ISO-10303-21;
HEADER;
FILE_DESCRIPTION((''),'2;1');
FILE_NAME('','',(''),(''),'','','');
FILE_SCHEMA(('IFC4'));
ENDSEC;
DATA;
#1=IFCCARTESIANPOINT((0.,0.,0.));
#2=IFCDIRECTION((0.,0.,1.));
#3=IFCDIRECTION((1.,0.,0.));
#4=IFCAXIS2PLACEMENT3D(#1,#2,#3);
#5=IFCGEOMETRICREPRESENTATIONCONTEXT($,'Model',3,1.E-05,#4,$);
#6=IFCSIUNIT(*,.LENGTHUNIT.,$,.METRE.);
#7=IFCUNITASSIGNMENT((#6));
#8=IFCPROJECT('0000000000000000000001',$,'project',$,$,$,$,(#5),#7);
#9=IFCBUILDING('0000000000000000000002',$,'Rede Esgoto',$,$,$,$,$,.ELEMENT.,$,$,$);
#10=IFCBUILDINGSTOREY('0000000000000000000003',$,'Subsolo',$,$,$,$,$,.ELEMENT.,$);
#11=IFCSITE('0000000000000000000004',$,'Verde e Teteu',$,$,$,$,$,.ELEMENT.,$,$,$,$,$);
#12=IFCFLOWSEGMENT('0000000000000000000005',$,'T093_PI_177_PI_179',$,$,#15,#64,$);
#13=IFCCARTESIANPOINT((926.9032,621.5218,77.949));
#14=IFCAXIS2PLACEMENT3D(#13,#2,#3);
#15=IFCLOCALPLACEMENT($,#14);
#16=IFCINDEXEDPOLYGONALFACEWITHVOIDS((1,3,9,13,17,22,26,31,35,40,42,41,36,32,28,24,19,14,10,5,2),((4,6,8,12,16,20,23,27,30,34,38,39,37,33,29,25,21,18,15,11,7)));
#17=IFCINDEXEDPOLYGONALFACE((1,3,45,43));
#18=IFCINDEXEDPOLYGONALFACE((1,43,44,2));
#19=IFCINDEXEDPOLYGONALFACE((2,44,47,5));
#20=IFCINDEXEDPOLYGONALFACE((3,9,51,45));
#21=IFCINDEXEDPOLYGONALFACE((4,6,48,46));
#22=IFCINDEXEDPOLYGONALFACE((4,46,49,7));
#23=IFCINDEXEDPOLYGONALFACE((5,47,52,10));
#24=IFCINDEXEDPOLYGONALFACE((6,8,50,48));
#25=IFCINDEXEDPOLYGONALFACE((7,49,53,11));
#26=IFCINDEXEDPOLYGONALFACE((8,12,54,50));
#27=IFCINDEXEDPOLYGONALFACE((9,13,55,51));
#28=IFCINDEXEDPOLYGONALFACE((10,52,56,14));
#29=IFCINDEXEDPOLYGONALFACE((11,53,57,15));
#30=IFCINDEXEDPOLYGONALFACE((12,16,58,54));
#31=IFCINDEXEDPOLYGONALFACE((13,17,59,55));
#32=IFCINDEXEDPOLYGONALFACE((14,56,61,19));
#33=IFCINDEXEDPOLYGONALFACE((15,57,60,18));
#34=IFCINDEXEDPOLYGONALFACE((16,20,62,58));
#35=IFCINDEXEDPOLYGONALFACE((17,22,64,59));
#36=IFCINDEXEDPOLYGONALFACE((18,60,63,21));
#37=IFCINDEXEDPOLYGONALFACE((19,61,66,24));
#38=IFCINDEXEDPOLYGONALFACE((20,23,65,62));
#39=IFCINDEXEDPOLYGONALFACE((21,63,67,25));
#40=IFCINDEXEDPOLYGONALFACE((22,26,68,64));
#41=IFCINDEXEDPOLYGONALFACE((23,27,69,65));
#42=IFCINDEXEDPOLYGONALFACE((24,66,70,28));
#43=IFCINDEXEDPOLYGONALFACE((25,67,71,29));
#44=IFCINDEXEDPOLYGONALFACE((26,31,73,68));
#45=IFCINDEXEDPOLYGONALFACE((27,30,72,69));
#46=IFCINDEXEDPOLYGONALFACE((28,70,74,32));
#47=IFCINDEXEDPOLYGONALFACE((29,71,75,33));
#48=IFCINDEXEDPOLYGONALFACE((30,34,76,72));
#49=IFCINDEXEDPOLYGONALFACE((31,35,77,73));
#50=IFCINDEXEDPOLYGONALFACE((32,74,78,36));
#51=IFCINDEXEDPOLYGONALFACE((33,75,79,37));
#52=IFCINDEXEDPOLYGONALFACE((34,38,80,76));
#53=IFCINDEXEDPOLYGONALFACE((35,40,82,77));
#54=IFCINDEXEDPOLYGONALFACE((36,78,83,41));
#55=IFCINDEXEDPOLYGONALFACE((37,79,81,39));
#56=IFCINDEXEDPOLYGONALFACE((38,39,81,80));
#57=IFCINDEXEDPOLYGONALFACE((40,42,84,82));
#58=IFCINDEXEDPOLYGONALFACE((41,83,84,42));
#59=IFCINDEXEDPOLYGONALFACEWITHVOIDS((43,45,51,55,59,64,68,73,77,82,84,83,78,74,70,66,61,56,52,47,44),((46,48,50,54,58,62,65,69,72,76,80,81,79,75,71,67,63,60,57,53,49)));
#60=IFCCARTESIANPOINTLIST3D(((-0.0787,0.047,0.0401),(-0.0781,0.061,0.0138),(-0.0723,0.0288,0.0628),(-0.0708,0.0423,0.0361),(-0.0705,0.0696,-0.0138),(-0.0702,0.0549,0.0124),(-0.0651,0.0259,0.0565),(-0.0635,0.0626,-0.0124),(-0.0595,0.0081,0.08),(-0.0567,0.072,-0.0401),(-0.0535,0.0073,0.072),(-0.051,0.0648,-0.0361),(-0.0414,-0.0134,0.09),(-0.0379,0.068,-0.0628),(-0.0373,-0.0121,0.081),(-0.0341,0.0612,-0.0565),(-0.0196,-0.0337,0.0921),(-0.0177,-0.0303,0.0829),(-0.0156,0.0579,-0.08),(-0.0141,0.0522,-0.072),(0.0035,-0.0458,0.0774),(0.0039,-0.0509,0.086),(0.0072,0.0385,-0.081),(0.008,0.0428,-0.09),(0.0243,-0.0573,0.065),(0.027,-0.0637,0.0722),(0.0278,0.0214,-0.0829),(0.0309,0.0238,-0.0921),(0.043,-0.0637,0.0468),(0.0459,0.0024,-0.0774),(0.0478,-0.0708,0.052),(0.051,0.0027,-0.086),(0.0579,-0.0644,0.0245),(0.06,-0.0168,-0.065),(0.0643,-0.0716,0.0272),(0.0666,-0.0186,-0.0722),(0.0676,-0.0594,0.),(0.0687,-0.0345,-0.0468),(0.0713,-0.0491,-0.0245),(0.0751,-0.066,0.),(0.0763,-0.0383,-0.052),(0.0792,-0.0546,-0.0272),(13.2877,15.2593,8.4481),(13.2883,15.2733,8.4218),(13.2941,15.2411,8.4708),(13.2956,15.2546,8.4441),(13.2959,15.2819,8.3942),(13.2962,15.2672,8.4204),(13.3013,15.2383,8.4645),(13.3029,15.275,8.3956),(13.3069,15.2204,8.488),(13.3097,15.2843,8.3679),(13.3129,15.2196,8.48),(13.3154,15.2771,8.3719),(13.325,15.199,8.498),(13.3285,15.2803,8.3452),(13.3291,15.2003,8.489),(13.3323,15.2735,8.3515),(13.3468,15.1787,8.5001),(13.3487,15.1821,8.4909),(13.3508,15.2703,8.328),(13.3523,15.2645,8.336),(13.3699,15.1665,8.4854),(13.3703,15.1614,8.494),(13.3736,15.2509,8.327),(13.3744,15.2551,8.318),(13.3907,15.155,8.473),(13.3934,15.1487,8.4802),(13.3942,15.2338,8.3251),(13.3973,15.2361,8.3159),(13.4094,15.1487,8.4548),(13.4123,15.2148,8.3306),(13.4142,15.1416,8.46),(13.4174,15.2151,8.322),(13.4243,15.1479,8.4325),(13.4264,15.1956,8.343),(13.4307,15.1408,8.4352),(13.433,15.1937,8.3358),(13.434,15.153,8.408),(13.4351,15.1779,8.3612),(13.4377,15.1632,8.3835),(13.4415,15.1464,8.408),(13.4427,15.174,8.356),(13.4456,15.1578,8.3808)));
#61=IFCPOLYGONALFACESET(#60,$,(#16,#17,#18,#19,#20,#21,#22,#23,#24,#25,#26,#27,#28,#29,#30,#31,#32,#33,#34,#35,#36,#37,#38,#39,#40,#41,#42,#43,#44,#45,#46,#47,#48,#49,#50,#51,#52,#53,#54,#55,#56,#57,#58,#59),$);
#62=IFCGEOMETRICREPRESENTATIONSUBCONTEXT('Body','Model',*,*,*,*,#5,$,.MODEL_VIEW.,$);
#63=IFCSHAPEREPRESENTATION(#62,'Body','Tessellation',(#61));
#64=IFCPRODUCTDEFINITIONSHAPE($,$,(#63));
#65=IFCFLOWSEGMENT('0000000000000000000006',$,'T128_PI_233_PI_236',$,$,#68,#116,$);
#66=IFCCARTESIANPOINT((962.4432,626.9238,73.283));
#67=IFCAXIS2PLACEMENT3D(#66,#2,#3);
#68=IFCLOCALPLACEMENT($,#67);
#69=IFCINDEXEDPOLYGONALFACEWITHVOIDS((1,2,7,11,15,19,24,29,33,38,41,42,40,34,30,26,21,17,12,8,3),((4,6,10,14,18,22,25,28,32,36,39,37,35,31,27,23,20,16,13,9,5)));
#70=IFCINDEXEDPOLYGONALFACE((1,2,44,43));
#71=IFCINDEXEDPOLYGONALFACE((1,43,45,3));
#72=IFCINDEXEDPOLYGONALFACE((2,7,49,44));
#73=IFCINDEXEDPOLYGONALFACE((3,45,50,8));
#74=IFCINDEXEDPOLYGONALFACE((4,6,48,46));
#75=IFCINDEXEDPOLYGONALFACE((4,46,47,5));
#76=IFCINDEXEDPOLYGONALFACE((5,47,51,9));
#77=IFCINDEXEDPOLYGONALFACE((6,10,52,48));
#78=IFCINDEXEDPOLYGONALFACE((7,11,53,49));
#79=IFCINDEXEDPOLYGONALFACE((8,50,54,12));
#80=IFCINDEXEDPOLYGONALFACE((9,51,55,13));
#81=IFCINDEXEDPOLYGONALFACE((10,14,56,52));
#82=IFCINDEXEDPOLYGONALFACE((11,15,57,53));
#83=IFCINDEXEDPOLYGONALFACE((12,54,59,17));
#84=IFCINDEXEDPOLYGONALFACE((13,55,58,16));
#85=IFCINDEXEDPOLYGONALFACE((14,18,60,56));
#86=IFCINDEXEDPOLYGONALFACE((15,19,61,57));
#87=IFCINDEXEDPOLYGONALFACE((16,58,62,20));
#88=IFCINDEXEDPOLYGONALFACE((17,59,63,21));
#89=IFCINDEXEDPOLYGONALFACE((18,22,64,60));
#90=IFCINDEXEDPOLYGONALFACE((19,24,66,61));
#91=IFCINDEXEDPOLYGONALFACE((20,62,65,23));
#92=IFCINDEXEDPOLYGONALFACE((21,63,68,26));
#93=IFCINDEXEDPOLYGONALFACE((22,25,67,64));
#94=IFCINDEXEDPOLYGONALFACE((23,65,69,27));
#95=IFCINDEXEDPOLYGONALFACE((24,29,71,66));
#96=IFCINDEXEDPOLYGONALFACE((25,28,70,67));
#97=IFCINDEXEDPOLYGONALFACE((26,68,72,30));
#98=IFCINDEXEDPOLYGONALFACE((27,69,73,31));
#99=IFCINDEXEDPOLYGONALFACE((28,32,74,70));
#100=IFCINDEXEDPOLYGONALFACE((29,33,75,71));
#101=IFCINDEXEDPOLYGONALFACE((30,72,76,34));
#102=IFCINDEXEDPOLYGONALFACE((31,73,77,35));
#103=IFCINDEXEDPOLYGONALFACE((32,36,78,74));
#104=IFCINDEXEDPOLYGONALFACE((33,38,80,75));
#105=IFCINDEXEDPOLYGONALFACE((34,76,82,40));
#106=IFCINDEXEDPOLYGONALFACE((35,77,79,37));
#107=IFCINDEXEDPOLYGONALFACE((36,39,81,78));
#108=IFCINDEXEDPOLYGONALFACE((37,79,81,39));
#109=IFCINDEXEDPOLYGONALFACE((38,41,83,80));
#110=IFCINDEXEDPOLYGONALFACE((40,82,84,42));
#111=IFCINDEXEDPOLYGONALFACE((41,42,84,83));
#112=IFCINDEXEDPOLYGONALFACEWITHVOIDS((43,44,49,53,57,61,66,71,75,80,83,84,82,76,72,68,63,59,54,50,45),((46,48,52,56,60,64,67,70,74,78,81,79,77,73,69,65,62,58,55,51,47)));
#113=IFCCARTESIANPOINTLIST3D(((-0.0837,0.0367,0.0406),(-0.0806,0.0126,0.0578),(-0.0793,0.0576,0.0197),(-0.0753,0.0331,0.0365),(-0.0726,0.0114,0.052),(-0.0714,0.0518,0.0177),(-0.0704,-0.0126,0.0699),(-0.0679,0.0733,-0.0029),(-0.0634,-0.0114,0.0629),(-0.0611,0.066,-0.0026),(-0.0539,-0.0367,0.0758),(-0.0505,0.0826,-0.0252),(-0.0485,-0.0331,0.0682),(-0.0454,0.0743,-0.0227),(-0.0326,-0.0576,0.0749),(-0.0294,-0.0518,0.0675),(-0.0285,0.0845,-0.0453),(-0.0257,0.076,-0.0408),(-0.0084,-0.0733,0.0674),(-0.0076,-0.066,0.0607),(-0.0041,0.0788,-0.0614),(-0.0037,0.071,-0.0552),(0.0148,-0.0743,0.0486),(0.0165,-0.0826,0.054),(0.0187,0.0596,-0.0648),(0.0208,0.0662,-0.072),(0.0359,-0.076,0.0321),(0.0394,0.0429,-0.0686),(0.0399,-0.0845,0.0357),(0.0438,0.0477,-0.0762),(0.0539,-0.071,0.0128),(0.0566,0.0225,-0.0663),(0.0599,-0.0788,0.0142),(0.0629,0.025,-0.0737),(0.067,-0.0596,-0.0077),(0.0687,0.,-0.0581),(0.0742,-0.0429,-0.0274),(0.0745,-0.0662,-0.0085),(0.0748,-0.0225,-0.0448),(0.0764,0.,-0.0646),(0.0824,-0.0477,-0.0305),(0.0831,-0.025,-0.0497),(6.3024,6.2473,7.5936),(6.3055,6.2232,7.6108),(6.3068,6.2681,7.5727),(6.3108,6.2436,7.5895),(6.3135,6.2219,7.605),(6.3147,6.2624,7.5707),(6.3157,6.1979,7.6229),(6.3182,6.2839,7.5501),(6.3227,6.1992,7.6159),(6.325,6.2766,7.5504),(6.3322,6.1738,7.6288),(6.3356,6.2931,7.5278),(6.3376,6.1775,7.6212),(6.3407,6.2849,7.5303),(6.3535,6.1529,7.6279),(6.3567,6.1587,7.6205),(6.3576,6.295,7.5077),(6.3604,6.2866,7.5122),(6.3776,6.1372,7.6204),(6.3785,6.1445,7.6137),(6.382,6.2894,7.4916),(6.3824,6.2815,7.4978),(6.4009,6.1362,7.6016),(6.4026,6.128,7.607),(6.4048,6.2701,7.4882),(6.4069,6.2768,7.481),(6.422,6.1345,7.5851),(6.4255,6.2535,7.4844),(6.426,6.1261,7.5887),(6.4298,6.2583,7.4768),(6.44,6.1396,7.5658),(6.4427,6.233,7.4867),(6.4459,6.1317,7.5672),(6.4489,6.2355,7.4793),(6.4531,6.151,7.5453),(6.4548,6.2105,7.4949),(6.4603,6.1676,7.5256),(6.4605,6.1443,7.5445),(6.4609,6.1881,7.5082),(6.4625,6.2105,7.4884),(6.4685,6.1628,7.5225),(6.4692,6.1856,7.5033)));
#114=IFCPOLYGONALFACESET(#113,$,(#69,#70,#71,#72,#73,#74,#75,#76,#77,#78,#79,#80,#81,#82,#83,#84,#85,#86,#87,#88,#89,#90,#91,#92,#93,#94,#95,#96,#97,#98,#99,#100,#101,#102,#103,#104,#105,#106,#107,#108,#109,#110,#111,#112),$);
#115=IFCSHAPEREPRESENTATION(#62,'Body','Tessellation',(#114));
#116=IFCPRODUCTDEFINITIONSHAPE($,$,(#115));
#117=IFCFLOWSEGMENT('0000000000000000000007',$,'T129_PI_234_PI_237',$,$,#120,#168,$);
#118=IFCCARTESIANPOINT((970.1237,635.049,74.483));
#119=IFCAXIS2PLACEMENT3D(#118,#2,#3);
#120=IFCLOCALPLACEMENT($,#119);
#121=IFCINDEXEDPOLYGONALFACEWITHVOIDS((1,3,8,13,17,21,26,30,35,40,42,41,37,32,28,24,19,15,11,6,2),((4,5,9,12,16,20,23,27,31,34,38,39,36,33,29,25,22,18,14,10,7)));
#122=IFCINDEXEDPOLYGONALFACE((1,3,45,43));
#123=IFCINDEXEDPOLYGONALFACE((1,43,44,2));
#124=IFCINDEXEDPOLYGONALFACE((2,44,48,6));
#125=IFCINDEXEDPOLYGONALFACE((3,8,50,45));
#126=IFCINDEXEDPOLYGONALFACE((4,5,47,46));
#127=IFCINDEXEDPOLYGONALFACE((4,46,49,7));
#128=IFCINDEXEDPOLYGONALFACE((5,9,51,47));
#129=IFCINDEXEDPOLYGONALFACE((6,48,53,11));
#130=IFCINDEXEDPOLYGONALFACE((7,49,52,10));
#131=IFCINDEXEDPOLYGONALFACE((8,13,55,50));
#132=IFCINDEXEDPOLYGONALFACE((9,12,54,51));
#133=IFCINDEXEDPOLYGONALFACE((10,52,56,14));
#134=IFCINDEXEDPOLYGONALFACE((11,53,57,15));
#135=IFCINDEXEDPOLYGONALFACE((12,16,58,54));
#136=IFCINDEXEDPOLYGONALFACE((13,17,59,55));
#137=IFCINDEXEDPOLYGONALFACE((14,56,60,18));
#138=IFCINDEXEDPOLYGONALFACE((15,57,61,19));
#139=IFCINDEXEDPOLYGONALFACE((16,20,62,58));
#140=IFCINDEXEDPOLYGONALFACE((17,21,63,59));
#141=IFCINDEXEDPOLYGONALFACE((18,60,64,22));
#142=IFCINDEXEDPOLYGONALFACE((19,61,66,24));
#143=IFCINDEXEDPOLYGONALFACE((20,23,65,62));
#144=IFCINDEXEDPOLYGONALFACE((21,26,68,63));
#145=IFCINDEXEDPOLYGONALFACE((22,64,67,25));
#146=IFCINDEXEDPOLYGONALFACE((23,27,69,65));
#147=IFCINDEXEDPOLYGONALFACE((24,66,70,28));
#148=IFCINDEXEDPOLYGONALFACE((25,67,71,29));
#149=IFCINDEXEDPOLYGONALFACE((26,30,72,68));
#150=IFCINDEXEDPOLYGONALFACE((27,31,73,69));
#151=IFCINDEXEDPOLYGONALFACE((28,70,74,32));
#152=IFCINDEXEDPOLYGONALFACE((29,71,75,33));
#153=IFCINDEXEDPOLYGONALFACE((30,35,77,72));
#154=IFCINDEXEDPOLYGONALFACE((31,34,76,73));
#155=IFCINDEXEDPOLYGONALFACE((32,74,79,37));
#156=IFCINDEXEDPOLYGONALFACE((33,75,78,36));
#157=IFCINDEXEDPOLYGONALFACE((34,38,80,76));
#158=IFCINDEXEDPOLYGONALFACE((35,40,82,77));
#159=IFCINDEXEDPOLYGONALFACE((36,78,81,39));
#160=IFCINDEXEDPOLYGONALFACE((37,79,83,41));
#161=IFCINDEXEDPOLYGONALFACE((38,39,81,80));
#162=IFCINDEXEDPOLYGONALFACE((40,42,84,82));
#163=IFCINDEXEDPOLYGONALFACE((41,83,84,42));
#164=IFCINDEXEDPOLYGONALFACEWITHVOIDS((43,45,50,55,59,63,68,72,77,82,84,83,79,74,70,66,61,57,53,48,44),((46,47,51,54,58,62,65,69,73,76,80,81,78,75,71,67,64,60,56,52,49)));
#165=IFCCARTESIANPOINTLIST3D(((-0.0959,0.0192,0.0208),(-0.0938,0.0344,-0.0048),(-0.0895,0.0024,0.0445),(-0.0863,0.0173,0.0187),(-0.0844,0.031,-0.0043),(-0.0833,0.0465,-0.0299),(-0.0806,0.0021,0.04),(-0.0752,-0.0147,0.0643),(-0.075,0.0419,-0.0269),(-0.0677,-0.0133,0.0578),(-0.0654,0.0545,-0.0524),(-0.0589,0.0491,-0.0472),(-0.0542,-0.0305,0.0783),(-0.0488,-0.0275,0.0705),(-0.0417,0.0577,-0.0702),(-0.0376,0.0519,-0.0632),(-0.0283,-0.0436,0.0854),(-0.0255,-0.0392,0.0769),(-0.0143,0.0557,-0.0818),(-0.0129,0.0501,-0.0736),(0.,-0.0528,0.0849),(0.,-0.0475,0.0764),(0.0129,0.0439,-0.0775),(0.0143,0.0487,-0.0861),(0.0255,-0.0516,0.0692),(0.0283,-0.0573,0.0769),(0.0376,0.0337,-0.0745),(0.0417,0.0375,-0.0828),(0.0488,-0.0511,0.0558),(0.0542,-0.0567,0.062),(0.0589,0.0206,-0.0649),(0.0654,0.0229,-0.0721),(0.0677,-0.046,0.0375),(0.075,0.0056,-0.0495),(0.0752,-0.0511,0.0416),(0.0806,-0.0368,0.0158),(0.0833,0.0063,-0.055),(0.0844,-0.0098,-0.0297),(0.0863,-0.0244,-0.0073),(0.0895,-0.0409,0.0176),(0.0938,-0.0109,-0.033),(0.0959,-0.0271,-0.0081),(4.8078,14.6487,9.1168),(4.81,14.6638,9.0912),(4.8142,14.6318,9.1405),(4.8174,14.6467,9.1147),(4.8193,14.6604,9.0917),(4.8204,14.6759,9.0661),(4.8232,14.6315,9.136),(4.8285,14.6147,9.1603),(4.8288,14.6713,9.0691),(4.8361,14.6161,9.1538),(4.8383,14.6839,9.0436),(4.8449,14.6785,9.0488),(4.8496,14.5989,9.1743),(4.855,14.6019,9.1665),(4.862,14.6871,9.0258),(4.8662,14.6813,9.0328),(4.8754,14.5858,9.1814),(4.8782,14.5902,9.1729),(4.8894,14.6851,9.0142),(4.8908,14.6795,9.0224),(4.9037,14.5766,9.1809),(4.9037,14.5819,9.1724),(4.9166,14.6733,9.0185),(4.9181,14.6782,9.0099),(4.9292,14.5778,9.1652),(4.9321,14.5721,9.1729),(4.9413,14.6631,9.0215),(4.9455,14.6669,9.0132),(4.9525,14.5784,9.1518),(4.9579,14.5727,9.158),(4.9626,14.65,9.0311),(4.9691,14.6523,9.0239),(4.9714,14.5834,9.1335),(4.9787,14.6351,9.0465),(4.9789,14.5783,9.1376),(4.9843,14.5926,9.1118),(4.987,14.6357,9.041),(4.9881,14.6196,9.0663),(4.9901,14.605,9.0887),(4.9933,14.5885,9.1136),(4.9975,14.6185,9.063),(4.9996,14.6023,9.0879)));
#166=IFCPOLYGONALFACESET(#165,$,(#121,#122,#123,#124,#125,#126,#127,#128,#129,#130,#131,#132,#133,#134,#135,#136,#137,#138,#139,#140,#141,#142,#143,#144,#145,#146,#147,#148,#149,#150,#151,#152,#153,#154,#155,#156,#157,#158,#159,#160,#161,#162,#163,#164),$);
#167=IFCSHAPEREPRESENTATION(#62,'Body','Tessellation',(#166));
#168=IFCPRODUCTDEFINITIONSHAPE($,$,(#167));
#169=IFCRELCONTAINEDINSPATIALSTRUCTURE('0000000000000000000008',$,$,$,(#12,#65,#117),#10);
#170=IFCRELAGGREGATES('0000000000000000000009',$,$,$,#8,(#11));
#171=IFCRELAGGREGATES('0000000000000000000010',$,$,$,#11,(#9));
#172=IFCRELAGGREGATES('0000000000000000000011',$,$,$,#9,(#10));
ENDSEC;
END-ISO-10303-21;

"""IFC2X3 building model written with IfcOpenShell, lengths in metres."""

from ifc_helpers import new_model, entity, si_unit, frame, origin_with_axes, place, context, subcontext, project, spatial, element, save


model = new_model("IFC2X3")

# Units and contexts
model_context = context("Model", 3, precision=1e-05, world=origin_with_axes())
body_context = subcontext(model_context, "Body", "Model", "MODEL_VIEW")
ifc_project = project(units=[si_unit("LENGTHUNIT", "METRE")], contexts=[model_context])

# Site, building, storey
site = spatial("IfcSite", under=ifc_project, Name="Verde e Teteu", CompositionType="ELEMENT")
building = spatial("IfcBuilding", under=site, Name="Rede Esgoto", CompositionType="ELEMENT")
storey = spatial("IfcBuildingStorey", under=building, Name="Subsolo", CompositionType="ELEMENT")

# Flow segments
flow_segment_1_placement = place(None, frame((926.9032, 621.5218, 77.949), z_axis=(0.0, 0.0, 1.0), x_axis=(1.0, 0.0, 0.0)))
element("IfcFlowSegment", 1, at=flow_segment_1_placement, inside=storey, Name="T093_PI_177_PI_179", context=body_context, shape_type="SweptSolid", body=[
    entity("IfcSweptDiskSolid", entity("IfcPolyline", [entity("IfcCartesianPoint", [0.0, 0.0, 0.0]), entity("IfcCartesianPoint", [13.3664, 15.2124, 8.408])]), 0.1, 0.09),
])
flow_segment_2_placement = place(None, frame((962.4432, 626.9238, 73.283), z_axis=(0.0, 0.0, 1.0), x_axis=(1.0, 0.0, 0.0)))
element("IfcFlowSegment", 2, at=flow_segment_2_placement, inside=storey, Name="T128_PI_233_PI_236", context=body_context, shape_type="SweptSolid", body=[
    entity("IfcSweptDiskSolid", entity("IfcPolyline", [entity("IfcCartesianPoint", [0.0, 0.0, 0.0]), entity("IfcCartesianPoint", [6.3861, 6.2105, 7.553])]), 0.1, 0.09),
])
flow_segment_3_placement = place(None, frame((970.1237, 635.049, 74.483), z_axis=(0.0, 0.0, 1.0), x_axis=(1.0, 0.0, 0.0)))
element("IfcFlowSegment", 3, at=flow_segment_3_placement, inside=storey, Name="T129_PI_234_PI_237", context=body_context, shape_type="SweptSolid", body=[
    entity("IfcSweptDiskSolid", entity("IfcPolyline", [entity("IfcCartesianPoint", [0.0, 0.0, 0.0]), entity("IfcCartesianPoint", [4.9037, 14.6294, 9.096])]), 0.1, 0.09),
])

save(model, "model.ifc")
